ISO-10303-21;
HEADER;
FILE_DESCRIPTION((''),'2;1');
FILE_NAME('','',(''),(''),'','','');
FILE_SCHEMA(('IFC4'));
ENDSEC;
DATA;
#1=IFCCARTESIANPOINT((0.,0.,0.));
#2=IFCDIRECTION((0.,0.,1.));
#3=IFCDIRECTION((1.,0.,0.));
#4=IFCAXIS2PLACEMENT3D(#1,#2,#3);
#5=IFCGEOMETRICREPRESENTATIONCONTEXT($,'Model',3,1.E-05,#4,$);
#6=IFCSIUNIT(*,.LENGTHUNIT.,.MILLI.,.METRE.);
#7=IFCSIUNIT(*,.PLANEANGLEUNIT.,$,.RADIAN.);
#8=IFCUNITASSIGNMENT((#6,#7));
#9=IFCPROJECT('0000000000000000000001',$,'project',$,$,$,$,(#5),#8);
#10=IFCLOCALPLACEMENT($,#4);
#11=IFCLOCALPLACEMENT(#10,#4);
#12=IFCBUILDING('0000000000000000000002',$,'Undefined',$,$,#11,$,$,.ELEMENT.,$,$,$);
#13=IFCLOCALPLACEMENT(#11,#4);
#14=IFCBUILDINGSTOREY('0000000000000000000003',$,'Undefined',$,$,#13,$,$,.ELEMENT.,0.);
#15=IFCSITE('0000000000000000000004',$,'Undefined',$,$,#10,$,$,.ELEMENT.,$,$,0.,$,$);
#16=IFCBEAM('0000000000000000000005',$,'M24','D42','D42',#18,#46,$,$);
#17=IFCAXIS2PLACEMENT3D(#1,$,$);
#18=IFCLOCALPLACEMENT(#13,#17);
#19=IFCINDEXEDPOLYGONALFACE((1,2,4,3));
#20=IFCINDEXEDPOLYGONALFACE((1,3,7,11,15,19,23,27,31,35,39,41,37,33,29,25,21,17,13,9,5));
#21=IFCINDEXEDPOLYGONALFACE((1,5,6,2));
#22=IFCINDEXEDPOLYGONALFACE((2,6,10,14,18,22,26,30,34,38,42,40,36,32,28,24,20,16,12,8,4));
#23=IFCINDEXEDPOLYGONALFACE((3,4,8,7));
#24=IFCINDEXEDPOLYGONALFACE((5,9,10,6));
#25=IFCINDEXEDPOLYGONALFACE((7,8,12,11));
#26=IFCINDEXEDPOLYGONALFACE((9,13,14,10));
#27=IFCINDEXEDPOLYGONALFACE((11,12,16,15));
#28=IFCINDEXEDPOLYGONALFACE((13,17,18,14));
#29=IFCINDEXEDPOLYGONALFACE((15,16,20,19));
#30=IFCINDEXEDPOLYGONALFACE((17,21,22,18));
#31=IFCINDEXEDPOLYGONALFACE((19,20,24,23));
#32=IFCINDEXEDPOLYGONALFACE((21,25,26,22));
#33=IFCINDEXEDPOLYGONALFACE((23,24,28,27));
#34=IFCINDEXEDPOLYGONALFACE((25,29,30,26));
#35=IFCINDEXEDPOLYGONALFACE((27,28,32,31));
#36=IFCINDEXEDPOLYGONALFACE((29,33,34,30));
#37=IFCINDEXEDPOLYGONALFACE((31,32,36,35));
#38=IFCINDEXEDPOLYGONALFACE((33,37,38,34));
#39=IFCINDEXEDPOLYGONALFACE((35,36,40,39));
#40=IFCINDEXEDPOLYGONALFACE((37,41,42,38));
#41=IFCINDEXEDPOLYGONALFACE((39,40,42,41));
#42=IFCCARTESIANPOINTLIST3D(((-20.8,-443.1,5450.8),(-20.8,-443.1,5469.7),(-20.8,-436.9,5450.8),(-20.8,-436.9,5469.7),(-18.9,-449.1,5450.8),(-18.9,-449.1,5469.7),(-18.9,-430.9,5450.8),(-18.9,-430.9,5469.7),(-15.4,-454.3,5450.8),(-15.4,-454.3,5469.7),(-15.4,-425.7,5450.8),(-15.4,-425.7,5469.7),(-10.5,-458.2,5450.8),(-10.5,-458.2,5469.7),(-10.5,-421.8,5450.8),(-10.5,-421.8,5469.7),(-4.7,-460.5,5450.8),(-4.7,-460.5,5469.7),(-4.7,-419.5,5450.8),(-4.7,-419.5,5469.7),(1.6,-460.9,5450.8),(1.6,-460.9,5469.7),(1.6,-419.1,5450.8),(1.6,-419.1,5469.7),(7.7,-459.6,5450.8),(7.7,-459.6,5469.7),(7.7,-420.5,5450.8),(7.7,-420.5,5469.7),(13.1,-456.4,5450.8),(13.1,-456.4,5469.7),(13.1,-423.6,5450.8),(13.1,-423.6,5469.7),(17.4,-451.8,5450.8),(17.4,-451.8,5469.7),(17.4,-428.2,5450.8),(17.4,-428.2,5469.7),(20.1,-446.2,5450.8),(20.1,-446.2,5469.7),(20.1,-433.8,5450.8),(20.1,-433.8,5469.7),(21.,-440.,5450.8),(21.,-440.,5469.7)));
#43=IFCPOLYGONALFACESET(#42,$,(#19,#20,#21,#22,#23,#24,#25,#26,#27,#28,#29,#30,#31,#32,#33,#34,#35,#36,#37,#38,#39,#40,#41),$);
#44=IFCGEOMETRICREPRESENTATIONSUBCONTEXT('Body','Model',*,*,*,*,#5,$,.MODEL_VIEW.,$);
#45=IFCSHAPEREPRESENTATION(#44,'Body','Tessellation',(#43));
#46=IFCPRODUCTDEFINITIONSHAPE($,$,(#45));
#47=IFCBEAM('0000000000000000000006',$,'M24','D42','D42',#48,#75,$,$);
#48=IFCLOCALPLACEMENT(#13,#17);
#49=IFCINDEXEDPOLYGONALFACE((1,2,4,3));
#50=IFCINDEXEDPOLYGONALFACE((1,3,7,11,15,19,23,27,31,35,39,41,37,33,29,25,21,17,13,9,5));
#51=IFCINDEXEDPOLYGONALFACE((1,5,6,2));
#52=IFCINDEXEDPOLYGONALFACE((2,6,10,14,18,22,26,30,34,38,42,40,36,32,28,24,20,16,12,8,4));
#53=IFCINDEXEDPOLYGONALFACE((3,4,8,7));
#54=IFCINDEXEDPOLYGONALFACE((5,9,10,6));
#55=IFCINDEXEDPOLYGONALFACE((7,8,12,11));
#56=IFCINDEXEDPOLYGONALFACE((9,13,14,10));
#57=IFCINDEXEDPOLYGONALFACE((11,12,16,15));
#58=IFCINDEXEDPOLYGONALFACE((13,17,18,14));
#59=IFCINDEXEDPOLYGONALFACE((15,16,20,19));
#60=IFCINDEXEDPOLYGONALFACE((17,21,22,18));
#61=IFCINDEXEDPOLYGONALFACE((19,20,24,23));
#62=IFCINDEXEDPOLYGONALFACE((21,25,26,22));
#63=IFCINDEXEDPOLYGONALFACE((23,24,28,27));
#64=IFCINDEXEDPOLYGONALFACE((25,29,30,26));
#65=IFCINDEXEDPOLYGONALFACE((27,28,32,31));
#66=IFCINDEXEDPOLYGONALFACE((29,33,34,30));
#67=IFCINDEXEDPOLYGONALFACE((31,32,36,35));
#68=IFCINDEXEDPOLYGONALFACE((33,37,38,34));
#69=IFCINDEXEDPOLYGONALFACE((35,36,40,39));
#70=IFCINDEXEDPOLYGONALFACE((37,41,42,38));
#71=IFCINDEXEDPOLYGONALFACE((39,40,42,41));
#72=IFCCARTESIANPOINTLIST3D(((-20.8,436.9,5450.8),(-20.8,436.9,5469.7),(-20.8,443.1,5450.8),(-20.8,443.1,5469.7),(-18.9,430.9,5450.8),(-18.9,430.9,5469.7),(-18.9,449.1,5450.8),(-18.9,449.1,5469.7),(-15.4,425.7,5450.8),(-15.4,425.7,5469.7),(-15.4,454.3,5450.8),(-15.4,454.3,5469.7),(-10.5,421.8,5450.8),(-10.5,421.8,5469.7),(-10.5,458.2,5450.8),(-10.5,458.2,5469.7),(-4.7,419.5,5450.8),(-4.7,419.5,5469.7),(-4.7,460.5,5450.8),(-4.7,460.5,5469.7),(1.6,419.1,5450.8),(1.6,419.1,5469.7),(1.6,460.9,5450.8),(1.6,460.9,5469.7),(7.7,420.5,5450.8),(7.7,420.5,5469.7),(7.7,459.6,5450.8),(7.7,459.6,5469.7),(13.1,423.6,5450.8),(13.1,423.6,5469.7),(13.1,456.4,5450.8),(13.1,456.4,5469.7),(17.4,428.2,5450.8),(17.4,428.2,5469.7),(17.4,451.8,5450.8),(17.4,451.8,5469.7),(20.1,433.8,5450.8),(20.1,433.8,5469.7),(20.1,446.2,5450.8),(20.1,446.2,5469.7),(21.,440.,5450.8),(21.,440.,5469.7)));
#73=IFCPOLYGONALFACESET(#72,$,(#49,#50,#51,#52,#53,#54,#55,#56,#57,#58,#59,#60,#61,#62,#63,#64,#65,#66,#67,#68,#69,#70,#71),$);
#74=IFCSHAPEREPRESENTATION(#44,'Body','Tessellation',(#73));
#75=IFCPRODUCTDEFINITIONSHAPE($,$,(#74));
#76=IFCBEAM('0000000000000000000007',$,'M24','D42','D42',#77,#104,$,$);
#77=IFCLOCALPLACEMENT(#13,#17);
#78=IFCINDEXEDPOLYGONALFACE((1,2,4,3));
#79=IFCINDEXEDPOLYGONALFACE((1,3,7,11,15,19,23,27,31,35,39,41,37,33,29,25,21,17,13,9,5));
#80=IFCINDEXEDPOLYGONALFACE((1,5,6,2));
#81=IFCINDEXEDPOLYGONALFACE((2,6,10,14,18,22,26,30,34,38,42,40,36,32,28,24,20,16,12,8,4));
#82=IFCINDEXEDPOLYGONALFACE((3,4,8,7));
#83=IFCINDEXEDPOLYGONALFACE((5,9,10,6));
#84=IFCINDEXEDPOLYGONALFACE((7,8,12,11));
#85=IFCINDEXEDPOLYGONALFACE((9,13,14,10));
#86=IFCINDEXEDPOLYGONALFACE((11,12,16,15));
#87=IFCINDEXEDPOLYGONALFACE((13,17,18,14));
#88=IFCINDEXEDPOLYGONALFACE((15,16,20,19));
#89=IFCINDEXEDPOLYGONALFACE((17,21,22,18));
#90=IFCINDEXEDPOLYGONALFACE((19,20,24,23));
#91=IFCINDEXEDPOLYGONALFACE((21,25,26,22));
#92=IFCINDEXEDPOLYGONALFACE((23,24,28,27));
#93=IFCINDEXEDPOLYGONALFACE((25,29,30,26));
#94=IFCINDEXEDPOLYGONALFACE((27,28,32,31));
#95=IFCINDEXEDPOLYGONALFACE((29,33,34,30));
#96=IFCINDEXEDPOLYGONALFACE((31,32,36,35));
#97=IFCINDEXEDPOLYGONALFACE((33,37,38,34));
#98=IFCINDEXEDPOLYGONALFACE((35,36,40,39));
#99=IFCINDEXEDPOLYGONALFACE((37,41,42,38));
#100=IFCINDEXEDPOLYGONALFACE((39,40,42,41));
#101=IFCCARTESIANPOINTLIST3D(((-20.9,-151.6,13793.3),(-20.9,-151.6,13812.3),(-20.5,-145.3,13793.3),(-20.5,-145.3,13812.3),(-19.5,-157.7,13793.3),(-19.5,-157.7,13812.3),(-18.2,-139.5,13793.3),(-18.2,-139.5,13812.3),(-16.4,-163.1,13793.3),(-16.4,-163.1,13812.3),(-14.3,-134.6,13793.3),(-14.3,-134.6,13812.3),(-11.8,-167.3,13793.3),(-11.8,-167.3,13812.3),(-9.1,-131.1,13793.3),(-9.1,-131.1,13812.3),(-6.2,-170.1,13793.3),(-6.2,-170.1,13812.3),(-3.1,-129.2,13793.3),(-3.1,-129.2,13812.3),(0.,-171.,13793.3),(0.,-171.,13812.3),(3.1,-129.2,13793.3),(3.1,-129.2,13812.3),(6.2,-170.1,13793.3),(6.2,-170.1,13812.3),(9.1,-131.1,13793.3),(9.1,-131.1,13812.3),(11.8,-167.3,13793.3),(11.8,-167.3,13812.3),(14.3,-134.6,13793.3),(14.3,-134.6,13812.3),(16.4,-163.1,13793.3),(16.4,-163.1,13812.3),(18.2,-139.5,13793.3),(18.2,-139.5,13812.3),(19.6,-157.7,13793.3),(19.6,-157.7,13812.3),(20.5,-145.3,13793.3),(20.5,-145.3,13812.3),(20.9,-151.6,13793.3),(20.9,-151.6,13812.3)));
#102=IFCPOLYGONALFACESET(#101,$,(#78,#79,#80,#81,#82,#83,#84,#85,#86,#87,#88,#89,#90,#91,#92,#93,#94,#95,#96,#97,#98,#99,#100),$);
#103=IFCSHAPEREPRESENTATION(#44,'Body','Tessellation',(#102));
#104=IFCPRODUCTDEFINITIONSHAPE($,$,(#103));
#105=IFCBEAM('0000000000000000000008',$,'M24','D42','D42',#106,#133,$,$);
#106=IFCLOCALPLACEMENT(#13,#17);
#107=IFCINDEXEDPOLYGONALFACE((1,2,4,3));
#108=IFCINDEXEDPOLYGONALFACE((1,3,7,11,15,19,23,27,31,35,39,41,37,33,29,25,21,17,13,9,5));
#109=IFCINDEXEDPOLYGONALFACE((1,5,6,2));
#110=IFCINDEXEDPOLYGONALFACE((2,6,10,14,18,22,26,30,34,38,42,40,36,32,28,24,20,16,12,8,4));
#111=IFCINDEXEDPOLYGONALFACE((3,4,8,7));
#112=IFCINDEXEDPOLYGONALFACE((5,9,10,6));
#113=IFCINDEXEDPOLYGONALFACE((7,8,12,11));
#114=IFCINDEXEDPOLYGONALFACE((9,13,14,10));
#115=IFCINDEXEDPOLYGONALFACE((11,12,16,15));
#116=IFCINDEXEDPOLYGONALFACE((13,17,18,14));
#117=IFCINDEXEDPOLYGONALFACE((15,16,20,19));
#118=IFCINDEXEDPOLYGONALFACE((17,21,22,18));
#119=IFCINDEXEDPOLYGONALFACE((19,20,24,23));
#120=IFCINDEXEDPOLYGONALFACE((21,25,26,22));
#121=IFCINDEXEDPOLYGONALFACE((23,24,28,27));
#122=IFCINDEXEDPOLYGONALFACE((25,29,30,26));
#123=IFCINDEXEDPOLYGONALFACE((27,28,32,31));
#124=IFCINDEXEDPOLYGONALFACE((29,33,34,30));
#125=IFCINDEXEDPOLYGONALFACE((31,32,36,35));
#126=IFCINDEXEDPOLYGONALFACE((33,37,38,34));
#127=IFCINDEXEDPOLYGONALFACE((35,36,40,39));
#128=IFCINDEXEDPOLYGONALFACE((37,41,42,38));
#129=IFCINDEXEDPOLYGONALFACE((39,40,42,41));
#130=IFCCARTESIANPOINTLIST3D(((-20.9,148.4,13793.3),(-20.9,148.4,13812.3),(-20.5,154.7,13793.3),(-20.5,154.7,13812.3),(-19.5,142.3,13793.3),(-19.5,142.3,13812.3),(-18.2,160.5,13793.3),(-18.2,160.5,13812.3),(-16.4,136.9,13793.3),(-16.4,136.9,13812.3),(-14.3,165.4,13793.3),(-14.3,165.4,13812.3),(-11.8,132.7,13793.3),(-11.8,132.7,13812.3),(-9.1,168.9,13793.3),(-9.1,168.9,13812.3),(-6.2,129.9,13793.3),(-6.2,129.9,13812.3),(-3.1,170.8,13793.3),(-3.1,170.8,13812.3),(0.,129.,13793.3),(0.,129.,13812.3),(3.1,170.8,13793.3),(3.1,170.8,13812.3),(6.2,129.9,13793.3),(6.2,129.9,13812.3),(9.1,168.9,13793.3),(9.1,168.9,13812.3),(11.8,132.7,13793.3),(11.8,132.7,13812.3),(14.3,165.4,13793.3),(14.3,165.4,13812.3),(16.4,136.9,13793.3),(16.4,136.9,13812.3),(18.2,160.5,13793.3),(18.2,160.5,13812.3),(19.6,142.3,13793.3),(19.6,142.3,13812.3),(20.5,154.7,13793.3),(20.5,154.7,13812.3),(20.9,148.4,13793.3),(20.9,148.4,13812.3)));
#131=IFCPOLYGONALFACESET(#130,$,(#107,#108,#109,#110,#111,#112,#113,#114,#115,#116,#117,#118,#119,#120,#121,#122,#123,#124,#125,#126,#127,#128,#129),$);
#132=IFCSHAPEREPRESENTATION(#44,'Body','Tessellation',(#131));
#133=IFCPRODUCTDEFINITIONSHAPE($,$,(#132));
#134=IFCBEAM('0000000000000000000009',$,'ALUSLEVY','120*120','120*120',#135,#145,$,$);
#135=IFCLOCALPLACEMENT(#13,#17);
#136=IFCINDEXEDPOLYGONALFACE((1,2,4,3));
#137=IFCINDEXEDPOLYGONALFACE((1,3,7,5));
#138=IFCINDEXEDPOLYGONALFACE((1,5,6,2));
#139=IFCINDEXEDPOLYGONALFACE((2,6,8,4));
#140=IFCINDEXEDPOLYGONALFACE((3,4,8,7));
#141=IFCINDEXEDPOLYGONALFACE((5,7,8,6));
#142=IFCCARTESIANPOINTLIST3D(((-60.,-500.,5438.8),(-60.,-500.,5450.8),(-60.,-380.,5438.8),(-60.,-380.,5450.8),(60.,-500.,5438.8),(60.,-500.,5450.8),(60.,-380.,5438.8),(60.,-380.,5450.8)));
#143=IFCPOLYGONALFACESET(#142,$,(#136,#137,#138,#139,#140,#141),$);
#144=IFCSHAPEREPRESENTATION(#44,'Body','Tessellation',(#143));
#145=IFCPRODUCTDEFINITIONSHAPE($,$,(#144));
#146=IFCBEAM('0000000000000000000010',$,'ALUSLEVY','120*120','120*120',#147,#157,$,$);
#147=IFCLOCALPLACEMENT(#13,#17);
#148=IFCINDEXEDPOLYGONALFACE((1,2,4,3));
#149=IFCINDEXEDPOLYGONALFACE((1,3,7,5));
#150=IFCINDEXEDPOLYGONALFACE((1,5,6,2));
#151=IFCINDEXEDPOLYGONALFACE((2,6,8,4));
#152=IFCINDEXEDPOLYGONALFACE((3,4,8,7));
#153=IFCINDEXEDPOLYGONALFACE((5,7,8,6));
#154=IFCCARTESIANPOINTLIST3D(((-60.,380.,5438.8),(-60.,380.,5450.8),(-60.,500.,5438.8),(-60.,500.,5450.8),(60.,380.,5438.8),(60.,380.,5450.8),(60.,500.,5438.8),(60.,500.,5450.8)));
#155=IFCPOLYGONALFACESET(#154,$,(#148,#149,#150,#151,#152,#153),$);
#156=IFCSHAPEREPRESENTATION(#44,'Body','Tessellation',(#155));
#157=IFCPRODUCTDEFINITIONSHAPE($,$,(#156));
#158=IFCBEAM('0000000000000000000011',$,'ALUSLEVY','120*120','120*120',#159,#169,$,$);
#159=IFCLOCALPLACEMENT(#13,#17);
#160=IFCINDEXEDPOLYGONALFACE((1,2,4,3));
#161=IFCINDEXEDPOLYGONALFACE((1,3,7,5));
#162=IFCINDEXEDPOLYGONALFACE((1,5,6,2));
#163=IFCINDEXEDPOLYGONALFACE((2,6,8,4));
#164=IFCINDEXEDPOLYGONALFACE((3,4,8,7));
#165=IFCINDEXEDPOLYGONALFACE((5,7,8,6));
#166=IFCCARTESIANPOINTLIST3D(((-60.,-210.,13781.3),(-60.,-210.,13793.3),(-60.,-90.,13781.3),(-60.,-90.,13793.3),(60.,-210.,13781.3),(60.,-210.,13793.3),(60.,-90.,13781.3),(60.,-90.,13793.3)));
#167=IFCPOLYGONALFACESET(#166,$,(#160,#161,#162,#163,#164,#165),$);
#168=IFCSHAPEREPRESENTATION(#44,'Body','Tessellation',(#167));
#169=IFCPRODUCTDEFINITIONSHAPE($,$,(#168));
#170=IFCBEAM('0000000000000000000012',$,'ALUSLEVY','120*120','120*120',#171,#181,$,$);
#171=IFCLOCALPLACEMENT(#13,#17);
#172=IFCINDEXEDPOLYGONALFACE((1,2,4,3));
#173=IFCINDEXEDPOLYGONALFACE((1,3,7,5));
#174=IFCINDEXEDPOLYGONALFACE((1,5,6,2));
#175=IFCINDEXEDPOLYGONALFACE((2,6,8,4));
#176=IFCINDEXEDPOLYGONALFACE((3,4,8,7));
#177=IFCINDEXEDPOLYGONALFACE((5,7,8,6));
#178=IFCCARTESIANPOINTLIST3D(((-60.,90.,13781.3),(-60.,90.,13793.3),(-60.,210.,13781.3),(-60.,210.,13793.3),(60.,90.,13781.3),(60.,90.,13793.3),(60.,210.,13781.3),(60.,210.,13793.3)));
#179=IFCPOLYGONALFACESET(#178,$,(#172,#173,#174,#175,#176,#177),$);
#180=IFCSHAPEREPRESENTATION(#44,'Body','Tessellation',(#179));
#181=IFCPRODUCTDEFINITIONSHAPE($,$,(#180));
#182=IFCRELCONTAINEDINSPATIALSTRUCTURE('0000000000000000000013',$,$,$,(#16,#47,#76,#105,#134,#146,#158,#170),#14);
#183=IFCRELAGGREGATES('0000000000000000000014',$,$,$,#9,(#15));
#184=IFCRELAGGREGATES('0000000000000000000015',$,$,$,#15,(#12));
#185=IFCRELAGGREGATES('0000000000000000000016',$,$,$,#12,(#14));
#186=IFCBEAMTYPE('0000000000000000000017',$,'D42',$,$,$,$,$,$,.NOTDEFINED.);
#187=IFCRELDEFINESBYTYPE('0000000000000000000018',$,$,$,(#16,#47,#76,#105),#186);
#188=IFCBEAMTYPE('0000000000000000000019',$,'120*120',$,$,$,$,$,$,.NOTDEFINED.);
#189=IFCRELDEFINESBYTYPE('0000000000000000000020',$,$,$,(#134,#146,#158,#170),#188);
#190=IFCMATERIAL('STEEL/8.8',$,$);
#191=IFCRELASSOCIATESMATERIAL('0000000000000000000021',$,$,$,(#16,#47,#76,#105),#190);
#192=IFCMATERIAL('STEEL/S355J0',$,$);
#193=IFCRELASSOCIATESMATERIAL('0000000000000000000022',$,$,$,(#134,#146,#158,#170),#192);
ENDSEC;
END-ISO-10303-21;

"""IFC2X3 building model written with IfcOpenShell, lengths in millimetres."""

from ifc_helpers import new_model, si_unit, frame, origin_with_axes, origin_2d_with_axis, place, context, subcontext, project, spatial, rectangle, circle, extrude, material, type_object, element, save


model = new_model("IFC2X3")

# Units and contexts
model_context = context("Model", 3, precision=1e-05, world=origin_with_axes())
body_context = subcontext(model_context, "Body", "Model", "MODEL_VIEW")
ifc_project = project(units=[si_unit("LENGTHUNIT", "METRE", prefix="MILLI"), si_unit("PLANEANGLEUNIT", "RADIAN")], contexts=[model_context])

# Site, building, storey
site_placement = place(None, origin_with_axes())
site = spatial("IfcSite", under=ifc_project, at=site_placement, Name="Undefined", CompositionType="ELEMENT", RefElevation=0.0)
building_placement = place(site_placement, origin_with_axes())
building = spatial("IfcBuilding", under=site, at=building_placement, Name="Undefined", CompositionType="ELEMENT")
storey_placement = place(building_placement, origin_with_axes())
storey = spatial("IfcBuildingStorey", under=building, at=storey_placement, Name="Undefined", CompositionType="ELEMENT", Elevation=0.0)

# Beams
ifc_material_1 = material(Name="STEEL/8.8")
beam_type_1 = type_object("IfcBeamType", Name="D42", PredefinedType="NOTDEFINED")
for number, where, z_axis, x_axis, name in (
    (1, (0.0, -440.0, 5450.8), (0.0, -1.0, -0.000016), (-0.000001, -0.000016, 1.0), "M24"),
    (2, (0.0, 440.0, 5450.8), (0.0, -1.0, 0.000016), (0.000001, 0.000016, 1.0), "M24"),
):
    element("IfcBeam", number, at=place(storey_placement, frame(where, z_axis=z_axis, x_axis=x_axis)), inside=storey, type_object=beam_type_1, material=ifc_material_1, Name=name, Description="D42", ObjectType="D42", context=body_context, shape_type="SweptSolid", body=[
        extrude(circle(Radius=21.0, at=origin_2d_with_axis()), frame((19.0, 0.0, 0.0), z_axis=(-1.0, 0.0, 0.0), x_axis=(0.0, -1.0, 0.0)), (0.0, 0.0, 1.0), 19.0),
    ])
beam_1_placement = place(storey_placement, frame((0.0, -150.0, 13793.3), z_axis=(-1.0, 0.0, 0.0), x_axis=(0.0, 0.0, 1.0)))
element("IfcBeam", 3, at=beam_1_placement, inside=storey, type_object=beam_type_1, material=ifc_material_1, Name="M24", Description="D42", ObjectType="D42", context=body_context, shape_type="SweptSolid", body=[
    extrude(circle(Radius=21.0, at=origin_2d_with_axis()), frame((19.0, 0.0, 0.0), z_axis=(-1.0, 0.0, 0.0), x_axis=(0.0, -1.0, 0.0)), (0.0, 0.0, 1.0), 19.0),
])
beam_2_placement = place(storey_placement, frame((0.0, 150.0, 13793.3), z_axis=(-1.0, 0.0, 0.0), x_axis=(0.0, 0.0, 1.0)))
element("IfcBeam", 4, at=beam_2_placement, inside=storey, type_object=beam_type_1, material=ifc_material_1, Name="M24", Description="D42", ObjectType="D42", context=body_context, shape_type="SweptSolid", body=[
    extrude(circle(Radius=21.0, at=origin_2d_with_axis()), frame((19.0, 0.0, 0.0), z_axis=(-1.0, 0.0, 0.0), x_axis=(0.0, -1.0, 0.0)), (0.0, 0.0, 1.0), 19.0),
])
ifc_material_2 = material(Name="STEEL/S355J0")
beam_type_2 = type_object("IfcBeamType", Name="120*120", PredefinedType="NOTDEFINED")
beam_3_placement = place(storey_placement, frame((0.0, -440.0, 5438.8), z_axis=(0.0, -1.0, -0.000016), x_axis=(-0.000001, -0.000016, 1.0)))
element("IfcBeam", 5, at=beam_3_placement, inside=storey, type_object=beam_type_2, material=ifc_material_2, Name="ALUSLEVY", Description="120*120", ObjectType="120*120", context=body_context, shape_type="SweptSolid", body=[
    extrude(rectangle(XDim=120.0, YDim=120.0, at=origin_2d_with_axis()), frame((12.0, 0.0, 0.0), z_axis=(-1.0, 0.0, 0.0), x_axis=(0.0, -1.0, 0.0)), (0.0, 0.0, 1.0), 12.0),
])
beam_4_placement = place(storey_placement, frame((0.0, 440.0, 5438.8), z_axis=(0.0, -1.0, 0.000016), x_axis=(0.000001, 0.000016, 1.0)))
element("IfcBeam", 6, at=beam_4_placement, inside=storey, type_object=beam_type_2, material=ifc_material_2, Name="ALUSLEVY", Description="120*120", ObjectType="120*120", context=body_context, shape_type="SweptSolid", body=[
    extrude(rectangle(XDim=120.0, YDim=120.0, at=origin_2d_with_axis()), frame((12.0, 0.0, 0.0), z_axis=(-1.0, 0.0, 0.0), x_axis=(0.0, -1.0, 0.0)), (0.0, 0.0, 1.0), 12.0),
])
for number, where, z_axis, x_axis, name in (
    (7, (0.0, -150.0, 13781.3), (1.0, 0.0, 0.0), (0.0, 0.0, 1.0), "ALUSLEVY"),
    (8, (0.0, 150.0, 13781.3), (1.0, 0.0, 0.0), (0.0, 0.0, 1.0), "ALUSLEVY"),
):
    element("IfcBeam", number, at=place(storey_placement, frame(where, z_axis=z_axis, x_axis=x_axis)), inside=storey, type_object=beam_type_2, material=ifc_material_2, Name=name, Description="120*120", ObjectType="120*120", context=body_context, shape_type="SweptSolid", body=[
        extrude(rectangle(XDim=120.0, YDim=120.0, at=origin_2d_with_axis()), frame((12.0, 0.0, 0.0), z_axis=(-1.0, 0.0, 0.0), x_axis=(0.0, -1.0, 0.0)), (0.0, 0.0, 1.0), 12.0),
    ])

save(model, "model.ifc")
